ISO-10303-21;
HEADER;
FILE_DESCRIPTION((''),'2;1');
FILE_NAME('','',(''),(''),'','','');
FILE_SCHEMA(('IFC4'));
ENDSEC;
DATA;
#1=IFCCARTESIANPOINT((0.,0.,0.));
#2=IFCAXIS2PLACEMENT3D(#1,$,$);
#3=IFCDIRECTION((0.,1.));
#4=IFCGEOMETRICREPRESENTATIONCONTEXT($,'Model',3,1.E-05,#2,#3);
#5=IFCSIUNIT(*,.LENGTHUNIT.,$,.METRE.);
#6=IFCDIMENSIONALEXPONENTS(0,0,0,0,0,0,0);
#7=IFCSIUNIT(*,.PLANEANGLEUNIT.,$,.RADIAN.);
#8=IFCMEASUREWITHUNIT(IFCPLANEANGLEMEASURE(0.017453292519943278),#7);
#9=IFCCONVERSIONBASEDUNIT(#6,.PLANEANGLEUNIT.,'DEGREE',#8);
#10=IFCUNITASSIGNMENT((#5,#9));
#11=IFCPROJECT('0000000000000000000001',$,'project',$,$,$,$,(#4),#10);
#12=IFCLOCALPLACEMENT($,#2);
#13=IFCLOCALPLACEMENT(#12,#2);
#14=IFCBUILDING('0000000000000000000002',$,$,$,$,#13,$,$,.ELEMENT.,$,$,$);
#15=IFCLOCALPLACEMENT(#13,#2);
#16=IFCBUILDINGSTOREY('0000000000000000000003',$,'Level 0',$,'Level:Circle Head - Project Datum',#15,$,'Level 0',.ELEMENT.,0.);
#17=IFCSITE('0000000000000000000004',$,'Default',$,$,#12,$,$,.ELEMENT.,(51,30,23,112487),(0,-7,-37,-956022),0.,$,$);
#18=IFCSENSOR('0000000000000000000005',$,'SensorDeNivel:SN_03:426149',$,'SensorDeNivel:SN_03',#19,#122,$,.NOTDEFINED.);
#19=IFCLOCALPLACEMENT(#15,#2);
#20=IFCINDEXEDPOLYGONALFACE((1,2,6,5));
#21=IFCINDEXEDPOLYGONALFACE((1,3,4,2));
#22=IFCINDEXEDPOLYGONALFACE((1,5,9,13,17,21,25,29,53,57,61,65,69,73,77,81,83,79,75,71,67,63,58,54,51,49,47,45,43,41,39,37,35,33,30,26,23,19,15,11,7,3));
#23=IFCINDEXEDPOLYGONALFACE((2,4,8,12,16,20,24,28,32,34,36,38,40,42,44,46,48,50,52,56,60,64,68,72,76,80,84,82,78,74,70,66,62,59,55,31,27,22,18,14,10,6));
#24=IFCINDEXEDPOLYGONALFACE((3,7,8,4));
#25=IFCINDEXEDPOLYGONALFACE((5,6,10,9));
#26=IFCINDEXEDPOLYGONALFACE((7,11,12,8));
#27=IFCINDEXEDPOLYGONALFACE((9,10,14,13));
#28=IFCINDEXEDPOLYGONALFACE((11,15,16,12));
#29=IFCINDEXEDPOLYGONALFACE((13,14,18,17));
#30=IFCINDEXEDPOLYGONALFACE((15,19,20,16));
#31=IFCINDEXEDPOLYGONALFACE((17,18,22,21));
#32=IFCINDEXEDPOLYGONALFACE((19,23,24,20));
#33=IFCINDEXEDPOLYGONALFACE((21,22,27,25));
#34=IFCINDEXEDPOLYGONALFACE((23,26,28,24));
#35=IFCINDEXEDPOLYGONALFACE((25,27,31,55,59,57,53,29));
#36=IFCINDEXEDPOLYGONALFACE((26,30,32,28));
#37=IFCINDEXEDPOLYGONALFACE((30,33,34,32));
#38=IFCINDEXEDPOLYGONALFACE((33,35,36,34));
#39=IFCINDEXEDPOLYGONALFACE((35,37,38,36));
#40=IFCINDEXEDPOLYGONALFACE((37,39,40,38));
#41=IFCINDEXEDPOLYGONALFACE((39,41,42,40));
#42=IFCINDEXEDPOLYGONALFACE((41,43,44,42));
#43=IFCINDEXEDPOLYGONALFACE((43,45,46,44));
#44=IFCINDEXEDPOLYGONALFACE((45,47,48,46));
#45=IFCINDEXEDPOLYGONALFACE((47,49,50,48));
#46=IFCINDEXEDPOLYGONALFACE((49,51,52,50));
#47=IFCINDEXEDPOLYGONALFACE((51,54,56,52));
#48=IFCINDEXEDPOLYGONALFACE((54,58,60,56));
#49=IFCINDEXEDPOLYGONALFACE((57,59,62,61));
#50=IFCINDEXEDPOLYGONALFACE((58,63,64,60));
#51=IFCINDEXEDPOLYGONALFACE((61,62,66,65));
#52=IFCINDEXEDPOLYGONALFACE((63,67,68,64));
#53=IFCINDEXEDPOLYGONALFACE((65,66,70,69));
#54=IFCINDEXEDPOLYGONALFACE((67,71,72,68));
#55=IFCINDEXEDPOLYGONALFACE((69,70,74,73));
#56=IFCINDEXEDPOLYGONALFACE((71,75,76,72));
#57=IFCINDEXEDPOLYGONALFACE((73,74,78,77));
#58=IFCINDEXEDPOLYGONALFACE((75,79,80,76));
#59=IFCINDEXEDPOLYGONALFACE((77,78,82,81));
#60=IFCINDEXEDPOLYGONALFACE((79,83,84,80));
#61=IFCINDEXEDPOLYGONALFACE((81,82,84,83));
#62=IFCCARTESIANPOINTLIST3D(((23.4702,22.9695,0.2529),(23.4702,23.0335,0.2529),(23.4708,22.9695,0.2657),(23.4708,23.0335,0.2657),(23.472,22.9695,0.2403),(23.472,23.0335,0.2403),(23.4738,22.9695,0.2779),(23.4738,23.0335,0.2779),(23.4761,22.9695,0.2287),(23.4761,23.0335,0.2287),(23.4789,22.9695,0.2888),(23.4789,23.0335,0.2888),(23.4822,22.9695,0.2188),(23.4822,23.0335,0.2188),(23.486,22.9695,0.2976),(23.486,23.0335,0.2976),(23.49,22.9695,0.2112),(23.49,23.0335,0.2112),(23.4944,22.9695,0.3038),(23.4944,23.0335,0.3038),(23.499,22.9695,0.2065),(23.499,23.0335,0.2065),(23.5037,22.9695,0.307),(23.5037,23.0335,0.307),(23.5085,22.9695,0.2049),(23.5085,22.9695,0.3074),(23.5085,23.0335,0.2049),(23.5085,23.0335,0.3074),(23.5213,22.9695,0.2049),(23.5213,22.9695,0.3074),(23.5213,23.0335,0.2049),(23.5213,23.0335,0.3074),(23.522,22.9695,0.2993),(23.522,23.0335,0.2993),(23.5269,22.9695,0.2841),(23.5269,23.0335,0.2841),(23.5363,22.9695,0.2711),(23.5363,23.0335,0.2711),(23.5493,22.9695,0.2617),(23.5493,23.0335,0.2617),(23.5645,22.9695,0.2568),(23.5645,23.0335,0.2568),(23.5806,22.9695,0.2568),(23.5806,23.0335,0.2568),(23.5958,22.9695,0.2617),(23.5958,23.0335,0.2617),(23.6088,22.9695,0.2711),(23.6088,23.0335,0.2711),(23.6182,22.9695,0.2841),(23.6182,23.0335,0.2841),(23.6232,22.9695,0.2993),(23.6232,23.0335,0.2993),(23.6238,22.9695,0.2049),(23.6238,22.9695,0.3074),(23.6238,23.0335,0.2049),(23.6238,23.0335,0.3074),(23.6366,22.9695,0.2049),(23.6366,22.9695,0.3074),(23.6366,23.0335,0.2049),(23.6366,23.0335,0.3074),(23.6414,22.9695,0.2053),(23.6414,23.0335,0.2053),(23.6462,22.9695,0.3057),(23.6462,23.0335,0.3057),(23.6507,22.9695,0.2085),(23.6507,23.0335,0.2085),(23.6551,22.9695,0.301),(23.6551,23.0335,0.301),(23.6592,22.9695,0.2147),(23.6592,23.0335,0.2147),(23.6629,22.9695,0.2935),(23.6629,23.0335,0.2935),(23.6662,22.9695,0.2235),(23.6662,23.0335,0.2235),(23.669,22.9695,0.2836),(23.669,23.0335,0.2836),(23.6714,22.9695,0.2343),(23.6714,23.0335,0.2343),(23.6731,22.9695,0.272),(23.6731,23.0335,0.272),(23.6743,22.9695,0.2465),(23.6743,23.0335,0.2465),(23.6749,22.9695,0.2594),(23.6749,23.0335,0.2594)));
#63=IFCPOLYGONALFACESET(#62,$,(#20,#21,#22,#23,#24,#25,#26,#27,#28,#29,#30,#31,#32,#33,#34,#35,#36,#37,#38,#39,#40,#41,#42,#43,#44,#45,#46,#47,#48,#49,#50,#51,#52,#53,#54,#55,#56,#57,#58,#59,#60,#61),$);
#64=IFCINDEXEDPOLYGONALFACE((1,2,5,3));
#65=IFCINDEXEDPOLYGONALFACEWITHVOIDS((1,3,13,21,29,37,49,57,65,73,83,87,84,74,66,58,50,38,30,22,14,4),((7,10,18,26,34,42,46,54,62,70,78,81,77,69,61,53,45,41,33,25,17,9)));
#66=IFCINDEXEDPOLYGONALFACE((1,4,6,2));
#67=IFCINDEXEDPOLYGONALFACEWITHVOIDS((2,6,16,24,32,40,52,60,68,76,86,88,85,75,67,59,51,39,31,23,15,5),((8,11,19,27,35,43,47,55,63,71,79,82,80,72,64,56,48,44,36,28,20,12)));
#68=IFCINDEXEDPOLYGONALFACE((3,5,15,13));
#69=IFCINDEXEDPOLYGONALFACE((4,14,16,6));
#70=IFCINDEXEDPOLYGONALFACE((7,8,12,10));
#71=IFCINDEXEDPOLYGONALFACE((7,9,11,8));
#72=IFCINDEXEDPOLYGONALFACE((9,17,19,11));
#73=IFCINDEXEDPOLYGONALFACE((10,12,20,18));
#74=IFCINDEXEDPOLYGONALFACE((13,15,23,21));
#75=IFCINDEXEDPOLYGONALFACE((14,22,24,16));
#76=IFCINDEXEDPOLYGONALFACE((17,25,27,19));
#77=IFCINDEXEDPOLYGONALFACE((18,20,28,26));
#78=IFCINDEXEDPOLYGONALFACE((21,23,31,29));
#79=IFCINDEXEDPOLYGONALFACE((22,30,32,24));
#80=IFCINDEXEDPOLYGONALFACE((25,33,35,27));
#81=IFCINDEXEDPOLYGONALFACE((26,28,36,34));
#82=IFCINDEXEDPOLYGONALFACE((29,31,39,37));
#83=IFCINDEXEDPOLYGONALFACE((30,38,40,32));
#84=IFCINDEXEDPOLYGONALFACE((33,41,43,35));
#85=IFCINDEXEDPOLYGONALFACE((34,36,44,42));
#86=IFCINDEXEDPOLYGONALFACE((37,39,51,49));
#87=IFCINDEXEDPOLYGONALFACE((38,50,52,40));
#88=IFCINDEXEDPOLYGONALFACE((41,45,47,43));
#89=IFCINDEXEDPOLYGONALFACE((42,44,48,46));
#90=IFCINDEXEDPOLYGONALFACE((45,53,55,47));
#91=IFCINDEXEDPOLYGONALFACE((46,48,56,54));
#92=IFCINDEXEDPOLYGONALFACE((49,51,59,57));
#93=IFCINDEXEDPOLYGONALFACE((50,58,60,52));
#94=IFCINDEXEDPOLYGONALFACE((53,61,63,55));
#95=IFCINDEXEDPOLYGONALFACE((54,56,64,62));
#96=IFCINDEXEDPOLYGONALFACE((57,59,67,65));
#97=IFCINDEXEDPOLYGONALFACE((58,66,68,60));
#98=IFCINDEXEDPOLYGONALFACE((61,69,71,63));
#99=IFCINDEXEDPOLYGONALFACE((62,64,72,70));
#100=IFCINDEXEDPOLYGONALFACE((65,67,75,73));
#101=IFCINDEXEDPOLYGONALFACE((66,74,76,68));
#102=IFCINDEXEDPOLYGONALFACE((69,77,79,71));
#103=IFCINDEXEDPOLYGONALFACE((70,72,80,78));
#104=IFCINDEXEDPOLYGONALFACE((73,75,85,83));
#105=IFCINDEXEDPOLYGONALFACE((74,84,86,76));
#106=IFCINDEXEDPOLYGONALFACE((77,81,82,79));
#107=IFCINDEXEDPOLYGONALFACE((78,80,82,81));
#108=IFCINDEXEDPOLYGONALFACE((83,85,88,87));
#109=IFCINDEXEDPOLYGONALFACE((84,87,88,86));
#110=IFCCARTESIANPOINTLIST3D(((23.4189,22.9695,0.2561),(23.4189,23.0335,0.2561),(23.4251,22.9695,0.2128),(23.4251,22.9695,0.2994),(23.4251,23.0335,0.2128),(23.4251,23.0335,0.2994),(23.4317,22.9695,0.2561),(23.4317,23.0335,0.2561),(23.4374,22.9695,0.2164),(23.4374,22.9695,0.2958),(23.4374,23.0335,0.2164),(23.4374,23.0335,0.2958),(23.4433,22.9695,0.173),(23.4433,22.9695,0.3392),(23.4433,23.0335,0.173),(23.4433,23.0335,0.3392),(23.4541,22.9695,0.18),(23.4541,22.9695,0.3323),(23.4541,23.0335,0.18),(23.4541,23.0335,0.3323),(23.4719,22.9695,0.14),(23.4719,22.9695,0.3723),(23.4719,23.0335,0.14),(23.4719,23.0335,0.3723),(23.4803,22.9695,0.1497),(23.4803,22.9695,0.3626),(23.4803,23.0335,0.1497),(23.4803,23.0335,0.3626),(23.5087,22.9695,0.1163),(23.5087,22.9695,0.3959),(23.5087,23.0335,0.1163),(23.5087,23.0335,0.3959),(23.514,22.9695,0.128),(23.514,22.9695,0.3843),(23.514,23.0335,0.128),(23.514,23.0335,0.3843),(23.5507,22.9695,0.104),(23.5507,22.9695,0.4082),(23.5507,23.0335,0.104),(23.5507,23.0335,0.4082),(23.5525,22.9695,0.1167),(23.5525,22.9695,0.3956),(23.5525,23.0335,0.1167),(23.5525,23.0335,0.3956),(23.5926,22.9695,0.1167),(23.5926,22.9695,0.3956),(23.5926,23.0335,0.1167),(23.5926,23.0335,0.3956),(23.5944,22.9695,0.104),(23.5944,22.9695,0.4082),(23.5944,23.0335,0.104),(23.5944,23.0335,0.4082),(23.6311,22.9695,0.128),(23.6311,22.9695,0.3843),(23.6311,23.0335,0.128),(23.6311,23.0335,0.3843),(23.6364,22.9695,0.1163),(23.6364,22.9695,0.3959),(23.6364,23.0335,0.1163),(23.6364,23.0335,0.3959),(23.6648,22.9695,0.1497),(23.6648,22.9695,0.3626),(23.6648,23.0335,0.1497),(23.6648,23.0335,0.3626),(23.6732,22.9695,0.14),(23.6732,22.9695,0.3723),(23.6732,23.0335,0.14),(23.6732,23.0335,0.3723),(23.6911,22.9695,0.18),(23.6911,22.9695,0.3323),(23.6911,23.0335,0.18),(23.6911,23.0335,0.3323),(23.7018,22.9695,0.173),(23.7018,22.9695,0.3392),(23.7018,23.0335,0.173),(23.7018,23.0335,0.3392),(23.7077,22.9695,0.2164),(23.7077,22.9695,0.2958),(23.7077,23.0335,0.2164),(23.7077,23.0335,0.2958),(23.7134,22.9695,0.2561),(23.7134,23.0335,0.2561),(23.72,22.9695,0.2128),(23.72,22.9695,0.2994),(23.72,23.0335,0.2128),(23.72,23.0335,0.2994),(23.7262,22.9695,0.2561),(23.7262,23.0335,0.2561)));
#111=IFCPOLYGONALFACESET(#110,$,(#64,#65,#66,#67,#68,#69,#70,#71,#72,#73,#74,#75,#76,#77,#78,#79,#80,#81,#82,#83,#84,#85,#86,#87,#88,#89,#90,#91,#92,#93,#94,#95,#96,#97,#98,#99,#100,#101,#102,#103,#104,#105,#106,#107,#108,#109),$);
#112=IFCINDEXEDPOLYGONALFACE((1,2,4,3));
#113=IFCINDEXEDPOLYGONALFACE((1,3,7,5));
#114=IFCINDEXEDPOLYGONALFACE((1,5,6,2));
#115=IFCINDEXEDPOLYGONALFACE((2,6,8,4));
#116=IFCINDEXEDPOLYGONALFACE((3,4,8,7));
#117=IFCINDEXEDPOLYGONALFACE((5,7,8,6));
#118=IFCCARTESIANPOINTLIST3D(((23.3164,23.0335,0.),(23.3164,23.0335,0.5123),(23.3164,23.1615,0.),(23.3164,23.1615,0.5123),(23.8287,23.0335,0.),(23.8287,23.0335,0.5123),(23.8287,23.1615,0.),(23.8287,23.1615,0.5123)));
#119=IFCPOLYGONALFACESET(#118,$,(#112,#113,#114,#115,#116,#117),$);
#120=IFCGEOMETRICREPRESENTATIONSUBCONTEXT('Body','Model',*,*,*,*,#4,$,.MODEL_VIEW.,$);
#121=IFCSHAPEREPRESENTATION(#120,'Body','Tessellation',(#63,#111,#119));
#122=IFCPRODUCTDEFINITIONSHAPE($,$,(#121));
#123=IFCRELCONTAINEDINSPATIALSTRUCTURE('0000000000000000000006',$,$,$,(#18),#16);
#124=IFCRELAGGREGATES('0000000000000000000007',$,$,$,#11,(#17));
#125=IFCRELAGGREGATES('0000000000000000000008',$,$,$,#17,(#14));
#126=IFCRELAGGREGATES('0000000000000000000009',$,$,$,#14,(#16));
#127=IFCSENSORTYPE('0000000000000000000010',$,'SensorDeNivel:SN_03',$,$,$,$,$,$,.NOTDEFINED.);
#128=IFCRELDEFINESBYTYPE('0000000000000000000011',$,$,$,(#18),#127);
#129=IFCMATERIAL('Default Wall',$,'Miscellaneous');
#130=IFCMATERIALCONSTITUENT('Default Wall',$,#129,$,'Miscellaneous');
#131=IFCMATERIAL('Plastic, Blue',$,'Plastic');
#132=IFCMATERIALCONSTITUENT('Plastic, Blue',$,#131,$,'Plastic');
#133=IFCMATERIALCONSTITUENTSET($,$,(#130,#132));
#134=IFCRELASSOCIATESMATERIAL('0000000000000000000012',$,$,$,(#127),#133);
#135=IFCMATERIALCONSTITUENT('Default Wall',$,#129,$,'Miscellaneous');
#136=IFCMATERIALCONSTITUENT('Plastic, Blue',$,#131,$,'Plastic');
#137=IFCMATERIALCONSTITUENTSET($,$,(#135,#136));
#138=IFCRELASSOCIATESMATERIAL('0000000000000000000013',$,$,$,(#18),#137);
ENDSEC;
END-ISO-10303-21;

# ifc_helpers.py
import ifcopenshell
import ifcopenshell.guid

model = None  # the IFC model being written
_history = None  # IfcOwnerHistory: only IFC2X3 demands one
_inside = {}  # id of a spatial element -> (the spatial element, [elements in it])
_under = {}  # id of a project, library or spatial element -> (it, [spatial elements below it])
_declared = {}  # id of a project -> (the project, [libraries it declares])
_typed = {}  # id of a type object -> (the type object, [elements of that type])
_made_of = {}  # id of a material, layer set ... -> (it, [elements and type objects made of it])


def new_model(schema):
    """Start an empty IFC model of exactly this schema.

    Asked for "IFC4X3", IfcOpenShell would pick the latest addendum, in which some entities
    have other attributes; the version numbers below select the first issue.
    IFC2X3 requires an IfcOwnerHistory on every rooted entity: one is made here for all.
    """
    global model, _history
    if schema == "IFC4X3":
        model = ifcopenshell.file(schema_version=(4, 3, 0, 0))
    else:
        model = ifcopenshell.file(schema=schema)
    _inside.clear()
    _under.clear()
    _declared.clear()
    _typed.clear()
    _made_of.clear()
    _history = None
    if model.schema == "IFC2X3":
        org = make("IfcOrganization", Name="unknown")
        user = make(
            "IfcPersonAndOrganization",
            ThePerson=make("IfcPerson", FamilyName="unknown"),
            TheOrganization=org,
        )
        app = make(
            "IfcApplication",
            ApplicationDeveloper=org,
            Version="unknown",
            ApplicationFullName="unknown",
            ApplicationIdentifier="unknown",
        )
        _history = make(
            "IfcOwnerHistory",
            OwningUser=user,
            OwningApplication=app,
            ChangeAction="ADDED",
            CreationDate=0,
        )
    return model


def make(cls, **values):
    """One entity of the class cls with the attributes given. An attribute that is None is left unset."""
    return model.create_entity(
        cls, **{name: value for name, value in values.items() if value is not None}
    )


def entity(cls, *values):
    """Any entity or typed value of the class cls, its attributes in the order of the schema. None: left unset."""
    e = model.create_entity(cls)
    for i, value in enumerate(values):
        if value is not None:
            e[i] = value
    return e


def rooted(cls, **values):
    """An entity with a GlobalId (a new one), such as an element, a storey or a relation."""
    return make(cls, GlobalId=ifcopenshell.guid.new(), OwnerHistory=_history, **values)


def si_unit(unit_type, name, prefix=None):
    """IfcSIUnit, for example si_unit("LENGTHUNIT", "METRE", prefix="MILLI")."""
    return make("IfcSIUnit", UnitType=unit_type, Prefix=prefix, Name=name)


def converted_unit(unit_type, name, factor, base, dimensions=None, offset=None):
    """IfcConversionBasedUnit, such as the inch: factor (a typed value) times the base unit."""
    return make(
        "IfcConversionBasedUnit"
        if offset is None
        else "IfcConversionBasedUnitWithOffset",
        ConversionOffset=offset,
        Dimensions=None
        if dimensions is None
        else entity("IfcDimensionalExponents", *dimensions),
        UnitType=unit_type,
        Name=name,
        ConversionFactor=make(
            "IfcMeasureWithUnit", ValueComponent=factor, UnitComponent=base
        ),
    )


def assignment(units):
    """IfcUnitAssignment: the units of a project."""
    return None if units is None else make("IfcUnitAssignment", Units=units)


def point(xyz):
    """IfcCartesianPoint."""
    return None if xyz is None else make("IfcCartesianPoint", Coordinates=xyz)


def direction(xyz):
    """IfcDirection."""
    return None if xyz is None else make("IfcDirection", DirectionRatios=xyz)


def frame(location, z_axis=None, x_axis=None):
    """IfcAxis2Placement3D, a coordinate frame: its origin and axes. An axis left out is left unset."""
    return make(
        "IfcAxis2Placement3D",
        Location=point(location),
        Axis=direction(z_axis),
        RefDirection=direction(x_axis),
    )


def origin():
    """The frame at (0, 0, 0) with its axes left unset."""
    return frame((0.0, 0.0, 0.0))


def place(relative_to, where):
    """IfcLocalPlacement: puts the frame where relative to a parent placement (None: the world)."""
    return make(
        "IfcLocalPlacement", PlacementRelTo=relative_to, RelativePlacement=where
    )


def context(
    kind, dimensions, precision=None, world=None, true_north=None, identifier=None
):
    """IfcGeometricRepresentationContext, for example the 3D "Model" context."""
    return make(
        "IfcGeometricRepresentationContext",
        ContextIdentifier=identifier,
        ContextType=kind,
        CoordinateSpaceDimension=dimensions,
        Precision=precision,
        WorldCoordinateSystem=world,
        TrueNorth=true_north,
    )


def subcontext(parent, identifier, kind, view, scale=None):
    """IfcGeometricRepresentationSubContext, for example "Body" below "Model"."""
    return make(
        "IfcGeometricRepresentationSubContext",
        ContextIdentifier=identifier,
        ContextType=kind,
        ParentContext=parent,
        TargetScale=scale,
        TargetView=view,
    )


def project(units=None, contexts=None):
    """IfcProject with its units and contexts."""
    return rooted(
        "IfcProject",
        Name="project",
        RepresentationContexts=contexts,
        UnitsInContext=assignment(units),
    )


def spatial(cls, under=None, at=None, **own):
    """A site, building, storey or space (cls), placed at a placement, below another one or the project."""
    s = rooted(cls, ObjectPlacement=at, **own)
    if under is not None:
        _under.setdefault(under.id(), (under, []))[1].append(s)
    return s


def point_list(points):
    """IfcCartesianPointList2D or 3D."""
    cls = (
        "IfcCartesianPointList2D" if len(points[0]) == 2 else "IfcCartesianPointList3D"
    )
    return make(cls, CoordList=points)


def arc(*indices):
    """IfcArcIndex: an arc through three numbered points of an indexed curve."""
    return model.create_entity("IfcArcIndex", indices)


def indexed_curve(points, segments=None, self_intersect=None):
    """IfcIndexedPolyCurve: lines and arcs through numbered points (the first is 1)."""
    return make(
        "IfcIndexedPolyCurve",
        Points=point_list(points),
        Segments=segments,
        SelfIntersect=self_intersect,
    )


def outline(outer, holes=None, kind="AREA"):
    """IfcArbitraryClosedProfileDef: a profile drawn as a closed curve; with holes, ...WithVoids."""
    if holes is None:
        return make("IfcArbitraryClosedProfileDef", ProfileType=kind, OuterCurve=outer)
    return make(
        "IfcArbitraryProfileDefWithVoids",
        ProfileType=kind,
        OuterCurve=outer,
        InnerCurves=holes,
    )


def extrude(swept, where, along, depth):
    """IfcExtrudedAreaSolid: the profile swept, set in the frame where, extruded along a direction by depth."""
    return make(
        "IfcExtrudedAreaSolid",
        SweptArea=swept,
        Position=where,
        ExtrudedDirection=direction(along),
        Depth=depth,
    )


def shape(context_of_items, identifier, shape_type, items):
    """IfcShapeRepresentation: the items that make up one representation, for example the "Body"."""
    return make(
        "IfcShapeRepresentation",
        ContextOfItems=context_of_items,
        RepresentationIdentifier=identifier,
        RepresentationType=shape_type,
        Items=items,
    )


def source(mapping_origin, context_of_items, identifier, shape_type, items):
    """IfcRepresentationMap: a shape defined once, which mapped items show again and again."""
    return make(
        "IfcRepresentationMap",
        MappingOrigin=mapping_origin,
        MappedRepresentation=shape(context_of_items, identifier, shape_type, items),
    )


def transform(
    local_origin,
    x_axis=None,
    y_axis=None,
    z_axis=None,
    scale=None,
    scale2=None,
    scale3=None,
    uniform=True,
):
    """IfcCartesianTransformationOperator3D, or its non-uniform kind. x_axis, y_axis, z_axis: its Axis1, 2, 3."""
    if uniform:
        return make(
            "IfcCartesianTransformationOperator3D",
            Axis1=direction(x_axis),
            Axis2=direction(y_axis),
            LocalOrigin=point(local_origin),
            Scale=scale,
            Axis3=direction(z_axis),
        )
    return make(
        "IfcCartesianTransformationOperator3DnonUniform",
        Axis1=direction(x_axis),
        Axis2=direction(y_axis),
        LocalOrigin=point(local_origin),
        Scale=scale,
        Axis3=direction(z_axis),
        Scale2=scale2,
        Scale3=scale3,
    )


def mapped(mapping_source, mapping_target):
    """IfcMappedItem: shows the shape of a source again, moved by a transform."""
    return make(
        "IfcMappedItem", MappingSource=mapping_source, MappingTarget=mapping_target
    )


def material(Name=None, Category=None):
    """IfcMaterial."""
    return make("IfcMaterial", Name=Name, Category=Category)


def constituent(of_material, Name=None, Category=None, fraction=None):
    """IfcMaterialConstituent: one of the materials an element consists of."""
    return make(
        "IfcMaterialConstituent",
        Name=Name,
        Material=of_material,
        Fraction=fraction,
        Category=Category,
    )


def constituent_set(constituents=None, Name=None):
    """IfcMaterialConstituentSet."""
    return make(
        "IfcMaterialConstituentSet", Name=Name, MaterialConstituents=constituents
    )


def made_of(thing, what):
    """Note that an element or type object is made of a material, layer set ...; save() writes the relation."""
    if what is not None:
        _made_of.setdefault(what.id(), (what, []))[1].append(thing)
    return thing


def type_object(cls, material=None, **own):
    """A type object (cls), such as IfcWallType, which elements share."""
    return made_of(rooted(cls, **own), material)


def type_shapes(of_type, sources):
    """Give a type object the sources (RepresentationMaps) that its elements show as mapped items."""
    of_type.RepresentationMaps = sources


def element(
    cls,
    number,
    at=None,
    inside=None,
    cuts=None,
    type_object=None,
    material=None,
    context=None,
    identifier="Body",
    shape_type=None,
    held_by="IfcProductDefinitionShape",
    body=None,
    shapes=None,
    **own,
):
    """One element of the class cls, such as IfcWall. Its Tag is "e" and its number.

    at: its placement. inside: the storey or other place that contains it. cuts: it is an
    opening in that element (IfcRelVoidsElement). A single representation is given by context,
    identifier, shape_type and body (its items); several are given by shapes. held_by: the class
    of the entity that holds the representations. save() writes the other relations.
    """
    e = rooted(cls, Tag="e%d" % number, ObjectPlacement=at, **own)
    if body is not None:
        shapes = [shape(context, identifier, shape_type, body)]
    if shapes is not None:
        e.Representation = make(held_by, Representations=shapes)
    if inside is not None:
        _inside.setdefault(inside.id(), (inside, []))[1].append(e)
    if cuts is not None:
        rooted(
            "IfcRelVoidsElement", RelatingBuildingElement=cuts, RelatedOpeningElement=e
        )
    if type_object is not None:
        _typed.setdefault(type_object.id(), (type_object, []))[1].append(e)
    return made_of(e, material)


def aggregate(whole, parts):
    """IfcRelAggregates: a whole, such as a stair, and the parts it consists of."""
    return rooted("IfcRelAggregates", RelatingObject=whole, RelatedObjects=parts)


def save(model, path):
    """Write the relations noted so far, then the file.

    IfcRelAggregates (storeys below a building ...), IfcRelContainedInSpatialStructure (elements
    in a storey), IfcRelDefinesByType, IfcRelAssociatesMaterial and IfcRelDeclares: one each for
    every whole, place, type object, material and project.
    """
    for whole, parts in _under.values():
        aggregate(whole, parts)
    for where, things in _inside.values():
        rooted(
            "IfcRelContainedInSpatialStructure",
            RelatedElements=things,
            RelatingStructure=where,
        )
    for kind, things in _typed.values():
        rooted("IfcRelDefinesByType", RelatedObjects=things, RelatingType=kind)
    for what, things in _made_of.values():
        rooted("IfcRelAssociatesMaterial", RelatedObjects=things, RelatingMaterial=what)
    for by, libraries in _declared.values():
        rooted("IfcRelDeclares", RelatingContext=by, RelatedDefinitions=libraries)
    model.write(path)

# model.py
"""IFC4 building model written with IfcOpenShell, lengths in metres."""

from ifc_helpers import new_model, entity, si_unit, converted_unit, direction, frame, origin, place, context, subcontext, project, spatial, arc, indexed_curve, outline, extrude, source, transform, mapped, material, constituent, constituent_set, type_object, type_shapes, element, save


model = new_model("IFC4")

# Units and contexts
model_context = context("Model", 3, precision=1e-05, world=origin(), true_north=direction((0.0, 1.0)))
body_context = subcontext(model_context, "Body", "Model", "MODEL_VIEW")
ifc_project = project(units=[si_unit("LENGTHUNIT", "METRE"), converted_unit("PLANEANGLEUNIT", "DEGREE", entity("IfcPlaneAngleMeasure", 0.017453292519943278), si_unit("PLANEANGLEUNIT", "RADIAN"), dimensions=[0, 0, 0, 0, 0, 0, 0])], contexts=[model_context])

# Site, building, storey
site_placement = place(None, origin())
site = spatial("IfcSite", under=ifc_project, at=site_placement, Name="Default", CompositionType="ELEMENT", RefLatitude=(51, 30, 23, 112487), RefLongitude=(0, -7, -37, -956022), RefElevation=0.0)
building_placement = place(site_placement, origin())
building = spatial("IfcBuilding", under=site, at=building_placement, CompositionType="ELEMENT")
storey_placement = place(building_placement, origin())
storey = spatial("IfcBuildingStorey", under=building, at=storey_placement, Name="Level 0", ObjectType="Level:Circle Head - Project Datum", LongName="Level 0", CompositionType="ELEMENT", Elevation=0.0)

# Sensor
ifc_material_1 = material(Name="Default Wall", Category="Miscellaneous")
ifc_constituent_1 = constituent(ifc_material_1, Name="Default Wall", Category="Miscellaneous")
ifc_material_2 = material(Name="Plastic, Blue", Category="Plastic")
ifc_constituent_2 = constituent(ifc_material_2, Name="Plastic, Blue", Category="Plastic")
ifc_constituent_set_1 = constituent_set(constituents=[ifc_constituent_1, ifc_constituent_2])
ifc_constituent_3 = constituent(ifc_material_1, Name="Default Wall", Category="Miscellaneous")
ifc_constituent_4 = constituent(ifc_material_2, Name="Plastic, Blue", Category="Plastic")
ifc_constituent_set_2 = constituent_set(constituents=[ifc_constituent_3, ifc_constituent_4])
sensor_type_1 = type_object("IfcSensorType", Name="SensorDeNivel:SN_03", PredefinedType="NOTDEFINED", material=ifc_constituent_set_2)
shared_shape_1 = source(origin(), body_context, "Body", "SweptSolid", [
    extrude(outline(indexed_curve([(0.0512, -0.0556), (0.064, -0.0556), (0.0736, -0.054), (0.0825, -0.0493), (0.0903, -0.0417), (0.0965, -0.0318), (0.1006, -0.0202), (0.1024, -0.0076), (0.1018, 0.0052), (0.0988, 0.0174), (0.0936, 0.0283), (0.0866, 0.037), (0.0782, 0.0432), (0.0689, 0.0464), (0.064, 0.0468), (0.0512, 0.0468), (0.0506, 0.0388), (0.0456, 0.0236), (0.0362, 0.0106), (0.0233, 0.0012), (0.008, -0.0038), (-0.008, -0.0038), (-0.0233, 0.0012), (-0.0362, 0.0106), (-0.0456, 0.0236), (-0.0506, 0.0388), (-0.0512, 0.0468), (-0.064, 0.0468), (-0.0736, 0.0452), (-0.0825, 0.0405), (-0.0903, 0.0329), (-0.0965, 0.023), (-0.1006, 0.0114), (-0.1024, -0.0012), (-0.1018, -0.014), (-0.0988, -0.0262), (-0.0936, -0.0371), (-0.0866, -0.0458), (-0.0782, -0.052), (-0.0689, -0.0552), (-0.064, -0.0556), (-0.0512, -0.0556), (0.0512, -0.0556)], self_intersect=False)), frame((0.0, -0.1281, 0.2605), z_axis=(0.0, 1.0, 0.0), x_axis=(-1.0, 0.0, 0.0)), (0.0, 0.0, 1.0), 0.064),
    extrude(outline(indexed_curve([(-0.1537, 0.0), (0.0, -0.1537), (0.1537, 0.0), (0.0, 0.1537)], segments=[arc(1, 2, 3), arc(3, 4, 1)], self_intersect=False), holes=[indexed_curve([(-0.1409, 0.0), (0.0, 0.1409), (0.1409, 0.0), (0.0, -0.1409)], segments=[arc(1, 2, 3), arc(3, 4, 1)], self_intersect=False)]), frame((0.0, -0.1281, 0.2561), z_axis=(0.0, 1.0, 0.0), x_axis=(1.0, 0.0, 0.0)), (0.0, 0.0, 1.0), 0.064),
    extrude(outline(indexed_curve([(-0.2561, -0.064), (0.2561, -0.064), (0.2561, 0.064), (-0.2561, 0.064), (-0.2561, -0.064)], self_intersect=False)), frame((0.0, 0.0, 0.0), z_axis=(0.0, 0.0, 1.0), x_axis=(-1.0, 0.0, 0.0)), (0.0, 0.0, 1.0), 0.5123),
])
type_shapes(sensor_type_1, [shared_shape_1])
sensor_1_placement = place(storey_placement, frame((23.5726, 23.0975, 0.0)))
element("IfcSensor", 1, at=sensor_1_placement, inside=storey, type_object=sensor_type_1, material=ifc_constituent_set_1, Name="SensorDeNivel:SN_03:426149", ObjectType="SensorDeNivel:SN_03", PredefinedType="NOTDEFINED", context=body_context, shape_type="MappedRepresentation", body=[
    mapped(shared_shape_1, transform((0.0, 0.0, 0.0), scale=1.0)),
])

save(model, "model.ifc")
